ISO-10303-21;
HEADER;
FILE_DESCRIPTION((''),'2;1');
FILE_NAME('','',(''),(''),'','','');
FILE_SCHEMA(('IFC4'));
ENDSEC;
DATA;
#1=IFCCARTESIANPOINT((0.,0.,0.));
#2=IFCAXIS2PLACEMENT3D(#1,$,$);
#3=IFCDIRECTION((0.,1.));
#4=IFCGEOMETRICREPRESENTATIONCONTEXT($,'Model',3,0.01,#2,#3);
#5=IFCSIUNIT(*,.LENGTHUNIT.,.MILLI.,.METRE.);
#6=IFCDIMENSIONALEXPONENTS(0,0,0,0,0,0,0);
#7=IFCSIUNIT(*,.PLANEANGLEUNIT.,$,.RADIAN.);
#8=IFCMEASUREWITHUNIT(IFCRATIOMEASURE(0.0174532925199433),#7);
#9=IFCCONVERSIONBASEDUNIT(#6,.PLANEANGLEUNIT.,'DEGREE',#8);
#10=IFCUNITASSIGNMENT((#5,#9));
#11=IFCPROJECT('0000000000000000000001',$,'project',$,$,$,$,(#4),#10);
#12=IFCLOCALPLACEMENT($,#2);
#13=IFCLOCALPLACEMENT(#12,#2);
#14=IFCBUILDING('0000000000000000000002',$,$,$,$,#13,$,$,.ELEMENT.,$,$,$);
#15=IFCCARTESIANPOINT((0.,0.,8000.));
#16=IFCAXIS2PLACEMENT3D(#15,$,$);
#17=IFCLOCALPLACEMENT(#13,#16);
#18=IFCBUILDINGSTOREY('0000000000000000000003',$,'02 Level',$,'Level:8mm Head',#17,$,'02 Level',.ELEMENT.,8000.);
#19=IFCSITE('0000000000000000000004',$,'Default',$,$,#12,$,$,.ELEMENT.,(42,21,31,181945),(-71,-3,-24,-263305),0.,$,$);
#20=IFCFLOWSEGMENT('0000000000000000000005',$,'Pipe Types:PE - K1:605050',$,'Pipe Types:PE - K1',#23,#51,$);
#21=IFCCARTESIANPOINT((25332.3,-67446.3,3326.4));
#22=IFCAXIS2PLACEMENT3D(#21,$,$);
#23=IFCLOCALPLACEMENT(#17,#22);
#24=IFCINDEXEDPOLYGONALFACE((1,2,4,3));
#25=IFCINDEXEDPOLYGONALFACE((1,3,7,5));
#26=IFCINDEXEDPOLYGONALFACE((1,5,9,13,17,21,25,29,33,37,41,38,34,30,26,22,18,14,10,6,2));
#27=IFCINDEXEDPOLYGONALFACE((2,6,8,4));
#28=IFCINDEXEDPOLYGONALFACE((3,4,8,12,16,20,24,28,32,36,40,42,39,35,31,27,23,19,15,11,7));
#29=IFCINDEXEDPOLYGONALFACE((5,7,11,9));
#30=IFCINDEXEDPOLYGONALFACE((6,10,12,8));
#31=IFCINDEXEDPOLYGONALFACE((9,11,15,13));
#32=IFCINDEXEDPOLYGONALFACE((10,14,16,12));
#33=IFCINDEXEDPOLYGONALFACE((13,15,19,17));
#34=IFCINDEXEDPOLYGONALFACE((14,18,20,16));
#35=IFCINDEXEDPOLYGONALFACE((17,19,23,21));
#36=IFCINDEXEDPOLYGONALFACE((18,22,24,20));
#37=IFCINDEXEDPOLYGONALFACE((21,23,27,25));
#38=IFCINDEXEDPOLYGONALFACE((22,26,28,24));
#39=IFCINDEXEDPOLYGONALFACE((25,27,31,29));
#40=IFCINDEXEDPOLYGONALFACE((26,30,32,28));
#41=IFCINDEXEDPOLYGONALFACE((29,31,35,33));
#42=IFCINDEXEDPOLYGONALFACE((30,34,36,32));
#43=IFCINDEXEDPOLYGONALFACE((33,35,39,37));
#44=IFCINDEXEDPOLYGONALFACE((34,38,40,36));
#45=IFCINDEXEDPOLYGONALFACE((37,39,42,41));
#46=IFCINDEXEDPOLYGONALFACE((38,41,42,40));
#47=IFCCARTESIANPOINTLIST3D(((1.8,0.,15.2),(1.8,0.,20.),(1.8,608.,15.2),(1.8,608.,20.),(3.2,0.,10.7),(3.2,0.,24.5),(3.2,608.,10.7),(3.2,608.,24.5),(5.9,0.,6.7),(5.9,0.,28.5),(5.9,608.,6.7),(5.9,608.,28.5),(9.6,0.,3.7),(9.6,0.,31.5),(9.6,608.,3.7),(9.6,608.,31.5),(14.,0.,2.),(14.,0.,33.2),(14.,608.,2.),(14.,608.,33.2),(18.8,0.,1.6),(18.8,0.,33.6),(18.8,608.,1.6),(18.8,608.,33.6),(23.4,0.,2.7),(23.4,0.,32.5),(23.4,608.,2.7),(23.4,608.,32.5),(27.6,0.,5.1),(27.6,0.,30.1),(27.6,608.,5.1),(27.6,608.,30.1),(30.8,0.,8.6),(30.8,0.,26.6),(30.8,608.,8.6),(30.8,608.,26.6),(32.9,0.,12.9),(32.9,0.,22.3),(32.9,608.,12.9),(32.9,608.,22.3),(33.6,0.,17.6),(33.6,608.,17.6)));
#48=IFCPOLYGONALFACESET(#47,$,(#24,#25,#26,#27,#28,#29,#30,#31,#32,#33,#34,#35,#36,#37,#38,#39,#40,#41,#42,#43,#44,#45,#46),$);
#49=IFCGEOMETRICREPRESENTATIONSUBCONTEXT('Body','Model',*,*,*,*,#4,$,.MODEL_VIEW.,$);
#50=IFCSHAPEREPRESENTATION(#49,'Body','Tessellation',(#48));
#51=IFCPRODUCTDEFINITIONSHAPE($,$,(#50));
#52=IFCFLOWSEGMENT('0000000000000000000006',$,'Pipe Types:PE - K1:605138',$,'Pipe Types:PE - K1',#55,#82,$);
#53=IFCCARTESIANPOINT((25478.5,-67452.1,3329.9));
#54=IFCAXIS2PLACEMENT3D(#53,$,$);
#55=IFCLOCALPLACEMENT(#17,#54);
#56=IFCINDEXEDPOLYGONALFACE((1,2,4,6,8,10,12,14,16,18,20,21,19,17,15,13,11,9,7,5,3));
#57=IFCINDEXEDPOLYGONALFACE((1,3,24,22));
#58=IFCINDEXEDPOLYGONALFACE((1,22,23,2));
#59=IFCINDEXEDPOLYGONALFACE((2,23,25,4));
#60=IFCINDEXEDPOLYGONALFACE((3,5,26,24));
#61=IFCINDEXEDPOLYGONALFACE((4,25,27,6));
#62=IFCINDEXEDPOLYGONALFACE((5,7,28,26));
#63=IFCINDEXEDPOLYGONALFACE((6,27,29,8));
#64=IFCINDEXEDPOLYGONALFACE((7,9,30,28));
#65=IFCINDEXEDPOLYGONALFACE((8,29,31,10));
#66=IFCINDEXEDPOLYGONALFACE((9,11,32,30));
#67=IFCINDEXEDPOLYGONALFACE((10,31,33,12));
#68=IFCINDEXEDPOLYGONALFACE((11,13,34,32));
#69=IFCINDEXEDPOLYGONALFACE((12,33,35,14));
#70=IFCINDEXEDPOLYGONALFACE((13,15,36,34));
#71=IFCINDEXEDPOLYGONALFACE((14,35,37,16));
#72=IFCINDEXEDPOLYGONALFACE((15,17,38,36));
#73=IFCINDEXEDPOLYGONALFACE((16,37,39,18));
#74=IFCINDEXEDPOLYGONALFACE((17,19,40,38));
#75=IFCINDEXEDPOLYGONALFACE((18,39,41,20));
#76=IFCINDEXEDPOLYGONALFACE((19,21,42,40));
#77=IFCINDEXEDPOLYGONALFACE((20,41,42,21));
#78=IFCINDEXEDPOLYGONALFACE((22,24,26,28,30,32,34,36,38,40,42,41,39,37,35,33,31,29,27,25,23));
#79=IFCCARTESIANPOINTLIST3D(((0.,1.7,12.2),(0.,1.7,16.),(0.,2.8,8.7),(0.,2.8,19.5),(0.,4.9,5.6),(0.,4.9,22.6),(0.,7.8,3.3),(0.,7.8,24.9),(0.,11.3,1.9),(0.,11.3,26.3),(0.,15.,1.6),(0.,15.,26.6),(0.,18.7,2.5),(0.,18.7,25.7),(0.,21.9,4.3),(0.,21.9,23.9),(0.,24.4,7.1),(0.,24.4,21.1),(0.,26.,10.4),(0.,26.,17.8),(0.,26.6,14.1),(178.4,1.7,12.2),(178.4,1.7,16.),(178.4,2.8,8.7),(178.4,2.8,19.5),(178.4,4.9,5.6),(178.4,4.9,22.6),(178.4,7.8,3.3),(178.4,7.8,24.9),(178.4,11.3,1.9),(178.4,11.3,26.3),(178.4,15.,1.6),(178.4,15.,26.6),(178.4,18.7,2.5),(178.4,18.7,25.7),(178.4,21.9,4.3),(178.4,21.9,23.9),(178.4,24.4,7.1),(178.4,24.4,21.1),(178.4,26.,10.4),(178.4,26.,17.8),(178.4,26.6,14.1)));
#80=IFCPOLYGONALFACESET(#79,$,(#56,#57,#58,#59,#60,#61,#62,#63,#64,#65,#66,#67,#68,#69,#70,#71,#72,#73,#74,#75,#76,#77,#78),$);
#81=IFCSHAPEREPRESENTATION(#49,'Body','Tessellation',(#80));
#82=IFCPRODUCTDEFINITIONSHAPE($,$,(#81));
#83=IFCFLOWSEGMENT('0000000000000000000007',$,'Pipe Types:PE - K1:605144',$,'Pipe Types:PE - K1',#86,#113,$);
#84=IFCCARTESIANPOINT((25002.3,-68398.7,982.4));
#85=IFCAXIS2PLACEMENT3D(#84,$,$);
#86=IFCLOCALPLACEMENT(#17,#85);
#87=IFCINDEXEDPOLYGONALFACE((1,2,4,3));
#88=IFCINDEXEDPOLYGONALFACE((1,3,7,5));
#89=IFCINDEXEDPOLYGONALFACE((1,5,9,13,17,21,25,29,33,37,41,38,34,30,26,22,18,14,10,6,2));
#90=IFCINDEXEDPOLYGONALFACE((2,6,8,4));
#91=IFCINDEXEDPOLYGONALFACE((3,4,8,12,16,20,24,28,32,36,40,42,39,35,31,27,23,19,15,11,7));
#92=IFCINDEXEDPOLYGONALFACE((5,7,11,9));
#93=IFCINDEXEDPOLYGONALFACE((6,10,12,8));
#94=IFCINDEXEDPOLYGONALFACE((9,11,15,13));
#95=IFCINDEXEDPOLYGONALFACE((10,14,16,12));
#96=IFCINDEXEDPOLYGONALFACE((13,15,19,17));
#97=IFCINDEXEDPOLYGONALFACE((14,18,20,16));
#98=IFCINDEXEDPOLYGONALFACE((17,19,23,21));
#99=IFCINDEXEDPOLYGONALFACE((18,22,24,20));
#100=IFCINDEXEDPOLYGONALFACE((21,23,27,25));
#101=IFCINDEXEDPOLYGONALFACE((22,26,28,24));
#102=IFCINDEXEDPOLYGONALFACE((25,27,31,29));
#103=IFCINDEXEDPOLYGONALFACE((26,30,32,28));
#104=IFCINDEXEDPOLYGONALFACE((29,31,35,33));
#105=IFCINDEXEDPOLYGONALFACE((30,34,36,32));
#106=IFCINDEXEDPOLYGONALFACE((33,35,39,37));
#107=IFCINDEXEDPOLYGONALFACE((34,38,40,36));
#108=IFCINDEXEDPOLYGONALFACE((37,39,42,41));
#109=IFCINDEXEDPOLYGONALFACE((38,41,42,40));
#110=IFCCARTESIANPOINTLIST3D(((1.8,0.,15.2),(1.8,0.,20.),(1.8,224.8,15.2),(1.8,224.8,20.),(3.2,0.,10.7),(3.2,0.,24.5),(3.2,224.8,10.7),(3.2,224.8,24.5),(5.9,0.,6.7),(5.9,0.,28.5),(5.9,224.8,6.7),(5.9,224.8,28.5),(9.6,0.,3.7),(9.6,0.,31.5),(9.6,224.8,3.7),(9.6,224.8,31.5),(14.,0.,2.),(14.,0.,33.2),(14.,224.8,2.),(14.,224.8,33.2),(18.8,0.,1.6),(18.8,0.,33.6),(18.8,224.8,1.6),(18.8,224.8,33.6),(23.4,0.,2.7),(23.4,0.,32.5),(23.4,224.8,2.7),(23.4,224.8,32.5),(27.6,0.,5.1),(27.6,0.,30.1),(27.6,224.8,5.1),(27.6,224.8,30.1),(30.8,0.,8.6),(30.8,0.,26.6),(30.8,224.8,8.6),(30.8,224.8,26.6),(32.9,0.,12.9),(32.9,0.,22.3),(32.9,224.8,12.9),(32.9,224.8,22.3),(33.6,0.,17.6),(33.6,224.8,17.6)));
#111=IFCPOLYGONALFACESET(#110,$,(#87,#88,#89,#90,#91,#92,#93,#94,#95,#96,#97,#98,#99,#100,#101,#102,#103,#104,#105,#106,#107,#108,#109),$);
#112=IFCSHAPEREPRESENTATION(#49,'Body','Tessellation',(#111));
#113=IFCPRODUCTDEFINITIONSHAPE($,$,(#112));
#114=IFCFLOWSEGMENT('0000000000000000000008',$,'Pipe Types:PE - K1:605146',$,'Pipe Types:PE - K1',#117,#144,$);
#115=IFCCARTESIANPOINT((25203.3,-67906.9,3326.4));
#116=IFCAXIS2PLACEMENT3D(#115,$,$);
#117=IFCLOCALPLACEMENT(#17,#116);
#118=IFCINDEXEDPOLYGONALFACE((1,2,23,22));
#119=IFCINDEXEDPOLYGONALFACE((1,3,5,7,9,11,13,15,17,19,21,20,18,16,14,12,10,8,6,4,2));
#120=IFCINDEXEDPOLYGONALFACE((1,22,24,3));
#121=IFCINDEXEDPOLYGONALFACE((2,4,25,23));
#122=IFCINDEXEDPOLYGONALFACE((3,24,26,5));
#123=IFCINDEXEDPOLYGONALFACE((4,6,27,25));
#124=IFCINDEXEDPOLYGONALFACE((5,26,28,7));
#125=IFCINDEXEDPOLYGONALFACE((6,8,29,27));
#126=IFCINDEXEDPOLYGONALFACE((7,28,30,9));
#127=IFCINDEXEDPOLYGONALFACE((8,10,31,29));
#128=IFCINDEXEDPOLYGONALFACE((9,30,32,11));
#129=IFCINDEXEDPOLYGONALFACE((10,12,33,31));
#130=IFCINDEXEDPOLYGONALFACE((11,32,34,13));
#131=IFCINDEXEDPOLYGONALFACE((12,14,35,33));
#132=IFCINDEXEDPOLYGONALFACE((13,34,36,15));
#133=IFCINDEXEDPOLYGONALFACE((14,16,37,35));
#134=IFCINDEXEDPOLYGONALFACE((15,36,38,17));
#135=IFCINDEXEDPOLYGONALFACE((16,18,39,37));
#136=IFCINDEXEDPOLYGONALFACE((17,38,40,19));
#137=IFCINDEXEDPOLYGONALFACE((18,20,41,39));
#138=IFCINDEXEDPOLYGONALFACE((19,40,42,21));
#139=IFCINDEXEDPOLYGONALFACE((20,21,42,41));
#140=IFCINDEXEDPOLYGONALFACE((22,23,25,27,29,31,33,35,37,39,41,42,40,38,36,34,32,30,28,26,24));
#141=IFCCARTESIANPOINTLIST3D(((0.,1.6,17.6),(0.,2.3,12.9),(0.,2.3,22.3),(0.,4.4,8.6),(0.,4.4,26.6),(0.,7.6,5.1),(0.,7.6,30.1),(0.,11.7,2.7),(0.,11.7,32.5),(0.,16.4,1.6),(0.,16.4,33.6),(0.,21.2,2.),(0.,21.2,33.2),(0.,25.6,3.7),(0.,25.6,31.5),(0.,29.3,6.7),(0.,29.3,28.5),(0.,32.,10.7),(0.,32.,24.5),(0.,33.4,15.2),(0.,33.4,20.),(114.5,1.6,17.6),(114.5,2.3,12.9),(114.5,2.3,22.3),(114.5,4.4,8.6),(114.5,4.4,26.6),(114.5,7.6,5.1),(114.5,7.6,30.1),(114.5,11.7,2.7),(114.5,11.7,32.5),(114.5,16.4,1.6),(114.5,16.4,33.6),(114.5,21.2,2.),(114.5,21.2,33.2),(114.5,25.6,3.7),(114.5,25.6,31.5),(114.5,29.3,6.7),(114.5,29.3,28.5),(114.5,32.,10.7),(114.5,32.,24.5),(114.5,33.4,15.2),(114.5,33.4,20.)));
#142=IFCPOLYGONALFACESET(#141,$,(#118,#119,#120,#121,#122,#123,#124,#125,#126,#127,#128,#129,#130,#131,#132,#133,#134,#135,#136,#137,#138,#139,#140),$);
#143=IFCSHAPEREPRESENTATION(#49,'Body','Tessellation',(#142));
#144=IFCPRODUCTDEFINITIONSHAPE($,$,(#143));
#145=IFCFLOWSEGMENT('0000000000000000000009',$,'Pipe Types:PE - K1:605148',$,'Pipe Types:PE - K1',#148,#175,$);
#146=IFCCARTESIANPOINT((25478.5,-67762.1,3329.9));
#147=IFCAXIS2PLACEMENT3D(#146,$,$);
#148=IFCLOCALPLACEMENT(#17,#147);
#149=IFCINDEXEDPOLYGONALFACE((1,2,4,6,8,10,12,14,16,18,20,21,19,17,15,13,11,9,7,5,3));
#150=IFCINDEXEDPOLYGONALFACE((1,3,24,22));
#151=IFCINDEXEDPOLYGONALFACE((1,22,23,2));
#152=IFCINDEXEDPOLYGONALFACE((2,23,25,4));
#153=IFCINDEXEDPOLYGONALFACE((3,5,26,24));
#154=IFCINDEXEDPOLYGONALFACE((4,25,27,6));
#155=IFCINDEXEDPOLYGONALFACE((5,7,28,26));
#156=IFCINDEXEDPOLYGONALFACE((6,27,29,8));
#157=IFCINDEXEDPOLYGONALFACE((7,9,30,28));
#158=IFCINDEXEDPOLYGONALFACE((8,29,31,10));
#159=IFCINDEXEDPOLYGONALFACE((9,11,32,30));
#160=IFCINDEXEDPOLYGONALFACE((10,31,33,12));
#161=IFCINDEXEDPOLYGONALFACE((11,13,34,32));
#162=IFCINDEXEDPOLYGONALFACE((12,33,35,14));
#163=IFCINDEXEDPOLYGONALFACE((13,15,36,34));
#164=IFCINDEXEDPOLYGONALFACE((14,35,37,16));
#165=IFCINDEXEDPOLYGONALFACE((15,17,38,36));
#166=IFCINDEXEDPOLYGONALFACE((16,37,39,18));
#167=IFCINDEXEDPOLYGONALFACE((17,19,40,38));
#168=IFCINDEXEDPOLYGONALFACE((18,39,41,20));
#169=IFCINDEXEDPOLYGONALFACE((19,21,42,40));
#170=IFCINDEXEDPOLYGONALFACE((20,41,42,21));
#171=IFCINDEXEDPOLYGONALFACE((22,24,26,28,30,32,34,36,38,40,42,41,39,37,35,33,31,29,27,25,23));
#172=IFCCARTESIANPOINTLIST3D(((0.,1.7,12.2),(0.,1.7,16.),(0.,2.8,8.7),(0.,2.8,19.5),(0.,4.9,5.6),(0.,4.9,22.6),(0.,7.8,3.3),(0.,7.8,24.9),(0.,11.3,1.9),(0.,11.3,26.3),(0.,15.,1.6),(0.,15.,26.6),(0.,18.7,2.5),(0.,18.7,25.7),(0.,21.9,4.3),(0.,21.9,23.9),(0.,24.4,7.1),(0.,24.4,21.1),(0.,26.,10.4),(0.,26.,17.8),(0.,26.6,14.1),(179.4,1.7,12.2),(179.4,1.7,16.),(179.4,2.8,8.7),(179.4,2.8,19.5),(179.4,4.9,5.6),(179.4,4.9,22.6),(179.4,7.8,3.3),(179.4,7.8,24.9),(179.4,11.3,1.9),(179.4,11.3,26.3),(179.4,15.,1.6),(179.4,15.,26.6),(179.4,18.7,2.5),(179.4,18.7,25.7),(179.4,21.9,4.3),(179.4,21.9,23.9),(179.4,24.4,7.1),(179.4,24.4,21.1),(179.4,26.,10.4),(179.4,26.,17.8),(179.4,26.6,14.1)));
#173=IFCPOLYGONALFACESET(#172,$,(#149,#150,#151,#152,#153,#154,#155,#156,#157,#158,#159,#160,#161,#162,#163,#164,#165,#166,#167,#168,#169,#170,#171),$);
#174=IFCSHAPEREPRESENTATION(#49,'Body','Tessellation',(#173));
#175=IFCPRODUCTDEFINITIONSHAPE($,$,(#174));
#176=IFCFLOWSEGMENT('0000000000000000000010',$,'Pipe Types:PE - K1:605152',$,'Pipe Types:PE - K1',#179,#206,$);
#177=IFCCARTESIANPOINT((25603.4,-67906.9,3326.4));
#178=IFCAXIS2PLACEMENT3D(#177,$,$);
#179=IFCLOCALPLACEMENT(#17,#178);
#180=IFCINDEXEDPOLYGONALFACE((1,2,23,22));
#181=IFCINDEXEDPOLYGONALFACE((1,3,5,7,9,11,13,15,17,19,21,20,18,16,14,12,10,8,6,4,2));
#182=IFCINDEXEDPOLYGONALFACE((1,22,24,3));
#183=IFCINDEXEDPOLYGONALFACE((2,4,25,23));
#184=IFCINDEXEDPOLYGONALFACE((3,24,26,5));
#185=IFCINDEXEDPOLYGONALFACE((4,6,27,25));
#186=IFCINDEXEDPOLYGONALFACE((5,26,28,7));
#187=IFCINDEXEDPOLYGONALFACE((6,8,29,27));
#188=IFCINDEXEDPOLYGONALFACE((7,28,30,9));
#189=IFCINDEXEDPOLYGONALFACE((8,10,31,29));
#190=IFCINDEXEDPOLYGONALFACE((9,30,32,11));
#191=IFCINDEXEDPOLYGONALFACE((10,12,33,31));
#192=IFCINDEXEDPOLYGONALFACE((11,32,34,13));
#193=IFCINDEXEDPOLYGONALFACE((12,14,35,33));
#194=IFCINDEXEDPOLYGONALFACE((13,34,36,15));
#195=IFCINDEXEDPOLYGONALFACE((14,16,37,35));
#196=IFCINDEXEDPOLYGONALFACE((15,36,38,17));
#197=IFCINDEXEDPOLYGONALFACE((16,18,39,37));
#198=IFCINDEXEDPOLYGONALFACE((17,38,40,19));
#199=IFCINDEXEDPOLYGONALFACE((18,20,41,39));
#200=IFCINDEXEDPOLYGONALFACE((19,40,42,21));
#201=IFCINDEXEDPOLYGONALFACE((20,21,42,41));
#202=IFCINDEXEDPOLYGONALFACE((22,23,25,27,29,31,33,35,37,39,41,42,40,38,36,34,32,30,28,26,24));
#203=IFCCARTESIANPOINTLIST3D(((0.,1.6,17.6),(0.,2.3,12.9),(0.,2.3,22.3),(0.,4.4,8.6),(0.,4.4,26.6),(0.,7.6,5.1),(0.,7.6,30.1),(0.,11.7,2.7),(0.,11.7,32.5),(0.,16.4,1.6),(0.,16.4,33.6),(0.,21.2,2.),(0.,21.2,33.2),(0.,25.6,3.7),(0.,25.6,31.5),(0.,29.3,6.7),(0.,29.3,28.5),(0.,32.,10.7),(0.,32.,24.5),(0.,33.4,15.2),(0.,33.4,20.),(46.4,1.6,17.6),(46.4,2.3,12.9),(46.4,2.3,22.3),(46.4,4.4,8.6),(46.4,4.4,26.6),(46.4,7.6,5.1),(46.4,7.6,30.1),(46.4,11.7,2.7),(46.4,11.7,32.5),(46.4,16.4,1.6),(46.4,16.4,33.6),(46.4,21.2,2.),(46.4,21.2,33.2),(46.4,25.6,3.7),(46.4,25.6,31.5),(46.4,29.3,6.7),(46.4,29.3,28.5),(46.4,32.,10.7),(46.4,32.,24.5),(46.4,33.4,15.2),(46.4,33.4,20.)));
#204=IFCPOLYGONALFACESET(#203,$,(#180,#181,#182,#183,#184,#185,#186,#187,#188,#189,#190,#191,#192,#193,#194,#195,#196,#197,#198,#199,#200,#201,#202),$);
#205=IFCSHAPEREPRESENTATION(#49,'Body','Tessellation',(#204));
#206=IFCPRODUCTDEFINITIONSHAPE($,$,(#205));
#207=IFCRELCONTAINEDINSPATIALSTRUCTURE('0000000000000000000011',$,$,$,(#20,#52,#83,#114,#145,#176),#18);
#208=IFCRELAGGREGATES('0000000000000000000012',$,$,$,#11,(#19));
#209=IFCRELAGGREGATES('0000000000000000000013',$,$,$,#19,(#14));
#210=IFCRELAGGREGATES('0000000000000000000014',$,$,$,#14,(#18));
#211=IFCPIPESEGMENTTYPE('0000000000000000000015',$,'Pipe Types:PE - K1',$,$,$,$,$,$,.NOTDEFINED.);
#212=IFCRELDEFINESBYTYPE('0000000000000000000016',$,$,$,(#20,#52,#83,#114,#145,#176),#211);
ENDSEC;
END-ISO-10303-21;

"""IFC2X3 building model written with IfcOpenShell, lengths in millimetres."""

from ifc_helpers import new_model, entity, si_unit, converted_unit, direction, frame, frame_2d, origin, origin_2d_with_axis, place, context, subcontext, project, spatial, circle, extrude, type_object, element, save


model = new_model("IFC2X3")

# Units and contexts
model_context = context("Model", 3, precision=0.01, world=origin(), true_north=direction((0.0, 1.0)))
body_context = subcontext(model_context, "Body", "Model", "MODEL_VIEW")
ifc_project = project(units=[si_unit("LENGTHUNIT", "METRE", prefix="MILLI"), converted_unit("PLANEANGLEUNIT", "DEGREE", entity("IfcRatioMeasure", 0.0174532925199433), si_unit("PLANEANGLEUNIT", "RADIAN"), dimensions=[0, 0, 0, 0, 0, 0, 0])], contexts=[model_context])

# Site, building, storey
site_placement = place(None, origin())
site = spatial("IfcSite", under=ifc_project, at=site_placement, Name="Default", CompositionType="ELEMENT", RefLatitude=(42, 21, 31, 181945), RefLongitude=(-71, -3, -24, -263305), RefElevation=0.0)
building_placement = place(site_placement, origin())
building = spatial("IfcBuilding", under=site, at=building_placement, CompositionType="ELEMENT")
storey_placement = place(building_placement, frame((0.0, 0.0, 8000.0)))
storey = spatial("IfcBuildingStorey", under=building, at=storey_placement, Name="02 Level", ObjectType="Level:8mm Head", LongName="02 Level", CompositionType="ELEMENT", Elevation=8000.0)

# Flow segments
pipe_segment_type = type_object("IfcPipeSegmentType", Name="Pipe Types:PE - K1", PredefinedType="NOTDEFINED")
flow_segment_1_placement = place(storey_placement, frame((25332.3, -67446.3, 3326.4)))
element("IfcFlowSegment", 1, at=flow_segment_1_placement, inside=storey, type_object=pipe_segment_type, Name="Pipe Types:PE - K1:605050", ObjectType="Pipe Types:PE - K1", context=body_context, shape_type="SweptSolid", body=[
    extrude(circle(Radius=16.0, at=origin_2d_with_axis()), frame((17.6, 0.0, 17.6), z_axis=(0.0, 1.0, 0.0), x_axis=(1.0, 0.0, 0.0)), (0.0, 0.0, 1.0), 608.0),
])
flow_segment_2_placement = place(storey_placement, frame((25478.5, -67452.1, 3329.9)))
element("IfcFlowSegment", 2, at=flow_segment_2_placement, inside=storey, type_object=pipe_segment_type, Name="Pipe Types:PE - K1:605138", ObjectType="Pipe Types:PE - K1", context=body_context, shape_type="SweptSolid", body=[
    extrude(circle(Radius=12.5, at=frame_2d((0.0, 0.0), x_axis=(1.0, 0.0))), frame((0.0, 14.1, 14.1), z_axis=(1.0, 0.0, 0.0), x_axis=(0.0, 1.0, 0.0)), (0.0, 0.0, 1.0), 178.4),
])
flow_segment_3_placement = place(storey_placement, frame((25002.3, -68398.7, 982.4)))
element("IfcFlowSegment", 3, at=flow_segment_3_placement, inside=storey, type_object=pipe_segment_type, Name="Pipe Types:PE - K1:605144", ObjectType="Pipe Types:PE - K1", context=body_context, shape_type="SweptSolid", body=[
    extrude(circle(Radius=16.0, at=frame_2d((0.0, 0.0), x_axis=(1.0, 0.0))), frame((17.6, 0.0, 17.6), z_axis=(0.0, 1.0, 0.0), x_axis=(1.0, 0.0, 0.0)), (0.0, 0.0, 1.0), 224.8),
])
flow_segment_4_placement = place(storey_placement, frame((25203.3, -67906.9, 3326.4)))
element("IfcFlowSegment", 4, at=flow_segment_4_placement, inside=storey, type_object=pipe_segment_type, Name="Pipe Types:PE - K1:605146", ObjectType="Pipe Types:PE - K1", context=body_context, shape_type="SweptSolid", body=[
    extrude(circle(Radius=16.0, at=origin_2d_with_axis()), frame((0.0, 17.6, 17.6), z_axis=(1.0, 0.0, 0.0), x_axis=(0.0, -1.0, 0.0)), (0.0, 0.0, 1.0), 114.5),
])
flow_segment_5_placement = place(storey_placement, frame((25478.5, -67762.1, 3329.9)))
element("IfcFlowSegment", 5, at=flow_segment_5_placement, inside=storey, type_object=pipe_segment_type, Name="Pipe Types:PE - K1:605148", ObjectType="Pipe Types:PE - K1", context=body_context, shape_type="SweptSolid", body=[
    extrude(circle(Radius=12.5, at=frame_2d((0.0, 0.0), x_axis=(1.0, 0.0))), frame((0.0, 14.1, 14.1), z_axis=(1.0, 0.0, 0.0), x_axis=(0.0, 1.0, 0.0)), (0.0, 0.0, 1.0), 179.4),
])
flow_segment_6_placement = place(storey_placement, frame((25603.4, -67906.9, 3326.4)))
element("IfcFlowSegment", 6, at=flow_segment_6_placement, inside=storey, type_object=pipe_segment_type, Name="Pipe Types:PE - K1:605152", ObjectType="Pipe Types:PE - K1", context=body_context, shape_type="SweptSolid", body=[
    extrude(circle(Radius=16.0, at=origin_2d_with_axis()), frame((0.0, 17.6, 17.6), z_axis=(1.0, 0.0, 0.0), x_axis=(0.0, -1.0, 0.0)), (0.0, 0.0, 1.0), 46.4),
])

save(model, "model.ifc")
